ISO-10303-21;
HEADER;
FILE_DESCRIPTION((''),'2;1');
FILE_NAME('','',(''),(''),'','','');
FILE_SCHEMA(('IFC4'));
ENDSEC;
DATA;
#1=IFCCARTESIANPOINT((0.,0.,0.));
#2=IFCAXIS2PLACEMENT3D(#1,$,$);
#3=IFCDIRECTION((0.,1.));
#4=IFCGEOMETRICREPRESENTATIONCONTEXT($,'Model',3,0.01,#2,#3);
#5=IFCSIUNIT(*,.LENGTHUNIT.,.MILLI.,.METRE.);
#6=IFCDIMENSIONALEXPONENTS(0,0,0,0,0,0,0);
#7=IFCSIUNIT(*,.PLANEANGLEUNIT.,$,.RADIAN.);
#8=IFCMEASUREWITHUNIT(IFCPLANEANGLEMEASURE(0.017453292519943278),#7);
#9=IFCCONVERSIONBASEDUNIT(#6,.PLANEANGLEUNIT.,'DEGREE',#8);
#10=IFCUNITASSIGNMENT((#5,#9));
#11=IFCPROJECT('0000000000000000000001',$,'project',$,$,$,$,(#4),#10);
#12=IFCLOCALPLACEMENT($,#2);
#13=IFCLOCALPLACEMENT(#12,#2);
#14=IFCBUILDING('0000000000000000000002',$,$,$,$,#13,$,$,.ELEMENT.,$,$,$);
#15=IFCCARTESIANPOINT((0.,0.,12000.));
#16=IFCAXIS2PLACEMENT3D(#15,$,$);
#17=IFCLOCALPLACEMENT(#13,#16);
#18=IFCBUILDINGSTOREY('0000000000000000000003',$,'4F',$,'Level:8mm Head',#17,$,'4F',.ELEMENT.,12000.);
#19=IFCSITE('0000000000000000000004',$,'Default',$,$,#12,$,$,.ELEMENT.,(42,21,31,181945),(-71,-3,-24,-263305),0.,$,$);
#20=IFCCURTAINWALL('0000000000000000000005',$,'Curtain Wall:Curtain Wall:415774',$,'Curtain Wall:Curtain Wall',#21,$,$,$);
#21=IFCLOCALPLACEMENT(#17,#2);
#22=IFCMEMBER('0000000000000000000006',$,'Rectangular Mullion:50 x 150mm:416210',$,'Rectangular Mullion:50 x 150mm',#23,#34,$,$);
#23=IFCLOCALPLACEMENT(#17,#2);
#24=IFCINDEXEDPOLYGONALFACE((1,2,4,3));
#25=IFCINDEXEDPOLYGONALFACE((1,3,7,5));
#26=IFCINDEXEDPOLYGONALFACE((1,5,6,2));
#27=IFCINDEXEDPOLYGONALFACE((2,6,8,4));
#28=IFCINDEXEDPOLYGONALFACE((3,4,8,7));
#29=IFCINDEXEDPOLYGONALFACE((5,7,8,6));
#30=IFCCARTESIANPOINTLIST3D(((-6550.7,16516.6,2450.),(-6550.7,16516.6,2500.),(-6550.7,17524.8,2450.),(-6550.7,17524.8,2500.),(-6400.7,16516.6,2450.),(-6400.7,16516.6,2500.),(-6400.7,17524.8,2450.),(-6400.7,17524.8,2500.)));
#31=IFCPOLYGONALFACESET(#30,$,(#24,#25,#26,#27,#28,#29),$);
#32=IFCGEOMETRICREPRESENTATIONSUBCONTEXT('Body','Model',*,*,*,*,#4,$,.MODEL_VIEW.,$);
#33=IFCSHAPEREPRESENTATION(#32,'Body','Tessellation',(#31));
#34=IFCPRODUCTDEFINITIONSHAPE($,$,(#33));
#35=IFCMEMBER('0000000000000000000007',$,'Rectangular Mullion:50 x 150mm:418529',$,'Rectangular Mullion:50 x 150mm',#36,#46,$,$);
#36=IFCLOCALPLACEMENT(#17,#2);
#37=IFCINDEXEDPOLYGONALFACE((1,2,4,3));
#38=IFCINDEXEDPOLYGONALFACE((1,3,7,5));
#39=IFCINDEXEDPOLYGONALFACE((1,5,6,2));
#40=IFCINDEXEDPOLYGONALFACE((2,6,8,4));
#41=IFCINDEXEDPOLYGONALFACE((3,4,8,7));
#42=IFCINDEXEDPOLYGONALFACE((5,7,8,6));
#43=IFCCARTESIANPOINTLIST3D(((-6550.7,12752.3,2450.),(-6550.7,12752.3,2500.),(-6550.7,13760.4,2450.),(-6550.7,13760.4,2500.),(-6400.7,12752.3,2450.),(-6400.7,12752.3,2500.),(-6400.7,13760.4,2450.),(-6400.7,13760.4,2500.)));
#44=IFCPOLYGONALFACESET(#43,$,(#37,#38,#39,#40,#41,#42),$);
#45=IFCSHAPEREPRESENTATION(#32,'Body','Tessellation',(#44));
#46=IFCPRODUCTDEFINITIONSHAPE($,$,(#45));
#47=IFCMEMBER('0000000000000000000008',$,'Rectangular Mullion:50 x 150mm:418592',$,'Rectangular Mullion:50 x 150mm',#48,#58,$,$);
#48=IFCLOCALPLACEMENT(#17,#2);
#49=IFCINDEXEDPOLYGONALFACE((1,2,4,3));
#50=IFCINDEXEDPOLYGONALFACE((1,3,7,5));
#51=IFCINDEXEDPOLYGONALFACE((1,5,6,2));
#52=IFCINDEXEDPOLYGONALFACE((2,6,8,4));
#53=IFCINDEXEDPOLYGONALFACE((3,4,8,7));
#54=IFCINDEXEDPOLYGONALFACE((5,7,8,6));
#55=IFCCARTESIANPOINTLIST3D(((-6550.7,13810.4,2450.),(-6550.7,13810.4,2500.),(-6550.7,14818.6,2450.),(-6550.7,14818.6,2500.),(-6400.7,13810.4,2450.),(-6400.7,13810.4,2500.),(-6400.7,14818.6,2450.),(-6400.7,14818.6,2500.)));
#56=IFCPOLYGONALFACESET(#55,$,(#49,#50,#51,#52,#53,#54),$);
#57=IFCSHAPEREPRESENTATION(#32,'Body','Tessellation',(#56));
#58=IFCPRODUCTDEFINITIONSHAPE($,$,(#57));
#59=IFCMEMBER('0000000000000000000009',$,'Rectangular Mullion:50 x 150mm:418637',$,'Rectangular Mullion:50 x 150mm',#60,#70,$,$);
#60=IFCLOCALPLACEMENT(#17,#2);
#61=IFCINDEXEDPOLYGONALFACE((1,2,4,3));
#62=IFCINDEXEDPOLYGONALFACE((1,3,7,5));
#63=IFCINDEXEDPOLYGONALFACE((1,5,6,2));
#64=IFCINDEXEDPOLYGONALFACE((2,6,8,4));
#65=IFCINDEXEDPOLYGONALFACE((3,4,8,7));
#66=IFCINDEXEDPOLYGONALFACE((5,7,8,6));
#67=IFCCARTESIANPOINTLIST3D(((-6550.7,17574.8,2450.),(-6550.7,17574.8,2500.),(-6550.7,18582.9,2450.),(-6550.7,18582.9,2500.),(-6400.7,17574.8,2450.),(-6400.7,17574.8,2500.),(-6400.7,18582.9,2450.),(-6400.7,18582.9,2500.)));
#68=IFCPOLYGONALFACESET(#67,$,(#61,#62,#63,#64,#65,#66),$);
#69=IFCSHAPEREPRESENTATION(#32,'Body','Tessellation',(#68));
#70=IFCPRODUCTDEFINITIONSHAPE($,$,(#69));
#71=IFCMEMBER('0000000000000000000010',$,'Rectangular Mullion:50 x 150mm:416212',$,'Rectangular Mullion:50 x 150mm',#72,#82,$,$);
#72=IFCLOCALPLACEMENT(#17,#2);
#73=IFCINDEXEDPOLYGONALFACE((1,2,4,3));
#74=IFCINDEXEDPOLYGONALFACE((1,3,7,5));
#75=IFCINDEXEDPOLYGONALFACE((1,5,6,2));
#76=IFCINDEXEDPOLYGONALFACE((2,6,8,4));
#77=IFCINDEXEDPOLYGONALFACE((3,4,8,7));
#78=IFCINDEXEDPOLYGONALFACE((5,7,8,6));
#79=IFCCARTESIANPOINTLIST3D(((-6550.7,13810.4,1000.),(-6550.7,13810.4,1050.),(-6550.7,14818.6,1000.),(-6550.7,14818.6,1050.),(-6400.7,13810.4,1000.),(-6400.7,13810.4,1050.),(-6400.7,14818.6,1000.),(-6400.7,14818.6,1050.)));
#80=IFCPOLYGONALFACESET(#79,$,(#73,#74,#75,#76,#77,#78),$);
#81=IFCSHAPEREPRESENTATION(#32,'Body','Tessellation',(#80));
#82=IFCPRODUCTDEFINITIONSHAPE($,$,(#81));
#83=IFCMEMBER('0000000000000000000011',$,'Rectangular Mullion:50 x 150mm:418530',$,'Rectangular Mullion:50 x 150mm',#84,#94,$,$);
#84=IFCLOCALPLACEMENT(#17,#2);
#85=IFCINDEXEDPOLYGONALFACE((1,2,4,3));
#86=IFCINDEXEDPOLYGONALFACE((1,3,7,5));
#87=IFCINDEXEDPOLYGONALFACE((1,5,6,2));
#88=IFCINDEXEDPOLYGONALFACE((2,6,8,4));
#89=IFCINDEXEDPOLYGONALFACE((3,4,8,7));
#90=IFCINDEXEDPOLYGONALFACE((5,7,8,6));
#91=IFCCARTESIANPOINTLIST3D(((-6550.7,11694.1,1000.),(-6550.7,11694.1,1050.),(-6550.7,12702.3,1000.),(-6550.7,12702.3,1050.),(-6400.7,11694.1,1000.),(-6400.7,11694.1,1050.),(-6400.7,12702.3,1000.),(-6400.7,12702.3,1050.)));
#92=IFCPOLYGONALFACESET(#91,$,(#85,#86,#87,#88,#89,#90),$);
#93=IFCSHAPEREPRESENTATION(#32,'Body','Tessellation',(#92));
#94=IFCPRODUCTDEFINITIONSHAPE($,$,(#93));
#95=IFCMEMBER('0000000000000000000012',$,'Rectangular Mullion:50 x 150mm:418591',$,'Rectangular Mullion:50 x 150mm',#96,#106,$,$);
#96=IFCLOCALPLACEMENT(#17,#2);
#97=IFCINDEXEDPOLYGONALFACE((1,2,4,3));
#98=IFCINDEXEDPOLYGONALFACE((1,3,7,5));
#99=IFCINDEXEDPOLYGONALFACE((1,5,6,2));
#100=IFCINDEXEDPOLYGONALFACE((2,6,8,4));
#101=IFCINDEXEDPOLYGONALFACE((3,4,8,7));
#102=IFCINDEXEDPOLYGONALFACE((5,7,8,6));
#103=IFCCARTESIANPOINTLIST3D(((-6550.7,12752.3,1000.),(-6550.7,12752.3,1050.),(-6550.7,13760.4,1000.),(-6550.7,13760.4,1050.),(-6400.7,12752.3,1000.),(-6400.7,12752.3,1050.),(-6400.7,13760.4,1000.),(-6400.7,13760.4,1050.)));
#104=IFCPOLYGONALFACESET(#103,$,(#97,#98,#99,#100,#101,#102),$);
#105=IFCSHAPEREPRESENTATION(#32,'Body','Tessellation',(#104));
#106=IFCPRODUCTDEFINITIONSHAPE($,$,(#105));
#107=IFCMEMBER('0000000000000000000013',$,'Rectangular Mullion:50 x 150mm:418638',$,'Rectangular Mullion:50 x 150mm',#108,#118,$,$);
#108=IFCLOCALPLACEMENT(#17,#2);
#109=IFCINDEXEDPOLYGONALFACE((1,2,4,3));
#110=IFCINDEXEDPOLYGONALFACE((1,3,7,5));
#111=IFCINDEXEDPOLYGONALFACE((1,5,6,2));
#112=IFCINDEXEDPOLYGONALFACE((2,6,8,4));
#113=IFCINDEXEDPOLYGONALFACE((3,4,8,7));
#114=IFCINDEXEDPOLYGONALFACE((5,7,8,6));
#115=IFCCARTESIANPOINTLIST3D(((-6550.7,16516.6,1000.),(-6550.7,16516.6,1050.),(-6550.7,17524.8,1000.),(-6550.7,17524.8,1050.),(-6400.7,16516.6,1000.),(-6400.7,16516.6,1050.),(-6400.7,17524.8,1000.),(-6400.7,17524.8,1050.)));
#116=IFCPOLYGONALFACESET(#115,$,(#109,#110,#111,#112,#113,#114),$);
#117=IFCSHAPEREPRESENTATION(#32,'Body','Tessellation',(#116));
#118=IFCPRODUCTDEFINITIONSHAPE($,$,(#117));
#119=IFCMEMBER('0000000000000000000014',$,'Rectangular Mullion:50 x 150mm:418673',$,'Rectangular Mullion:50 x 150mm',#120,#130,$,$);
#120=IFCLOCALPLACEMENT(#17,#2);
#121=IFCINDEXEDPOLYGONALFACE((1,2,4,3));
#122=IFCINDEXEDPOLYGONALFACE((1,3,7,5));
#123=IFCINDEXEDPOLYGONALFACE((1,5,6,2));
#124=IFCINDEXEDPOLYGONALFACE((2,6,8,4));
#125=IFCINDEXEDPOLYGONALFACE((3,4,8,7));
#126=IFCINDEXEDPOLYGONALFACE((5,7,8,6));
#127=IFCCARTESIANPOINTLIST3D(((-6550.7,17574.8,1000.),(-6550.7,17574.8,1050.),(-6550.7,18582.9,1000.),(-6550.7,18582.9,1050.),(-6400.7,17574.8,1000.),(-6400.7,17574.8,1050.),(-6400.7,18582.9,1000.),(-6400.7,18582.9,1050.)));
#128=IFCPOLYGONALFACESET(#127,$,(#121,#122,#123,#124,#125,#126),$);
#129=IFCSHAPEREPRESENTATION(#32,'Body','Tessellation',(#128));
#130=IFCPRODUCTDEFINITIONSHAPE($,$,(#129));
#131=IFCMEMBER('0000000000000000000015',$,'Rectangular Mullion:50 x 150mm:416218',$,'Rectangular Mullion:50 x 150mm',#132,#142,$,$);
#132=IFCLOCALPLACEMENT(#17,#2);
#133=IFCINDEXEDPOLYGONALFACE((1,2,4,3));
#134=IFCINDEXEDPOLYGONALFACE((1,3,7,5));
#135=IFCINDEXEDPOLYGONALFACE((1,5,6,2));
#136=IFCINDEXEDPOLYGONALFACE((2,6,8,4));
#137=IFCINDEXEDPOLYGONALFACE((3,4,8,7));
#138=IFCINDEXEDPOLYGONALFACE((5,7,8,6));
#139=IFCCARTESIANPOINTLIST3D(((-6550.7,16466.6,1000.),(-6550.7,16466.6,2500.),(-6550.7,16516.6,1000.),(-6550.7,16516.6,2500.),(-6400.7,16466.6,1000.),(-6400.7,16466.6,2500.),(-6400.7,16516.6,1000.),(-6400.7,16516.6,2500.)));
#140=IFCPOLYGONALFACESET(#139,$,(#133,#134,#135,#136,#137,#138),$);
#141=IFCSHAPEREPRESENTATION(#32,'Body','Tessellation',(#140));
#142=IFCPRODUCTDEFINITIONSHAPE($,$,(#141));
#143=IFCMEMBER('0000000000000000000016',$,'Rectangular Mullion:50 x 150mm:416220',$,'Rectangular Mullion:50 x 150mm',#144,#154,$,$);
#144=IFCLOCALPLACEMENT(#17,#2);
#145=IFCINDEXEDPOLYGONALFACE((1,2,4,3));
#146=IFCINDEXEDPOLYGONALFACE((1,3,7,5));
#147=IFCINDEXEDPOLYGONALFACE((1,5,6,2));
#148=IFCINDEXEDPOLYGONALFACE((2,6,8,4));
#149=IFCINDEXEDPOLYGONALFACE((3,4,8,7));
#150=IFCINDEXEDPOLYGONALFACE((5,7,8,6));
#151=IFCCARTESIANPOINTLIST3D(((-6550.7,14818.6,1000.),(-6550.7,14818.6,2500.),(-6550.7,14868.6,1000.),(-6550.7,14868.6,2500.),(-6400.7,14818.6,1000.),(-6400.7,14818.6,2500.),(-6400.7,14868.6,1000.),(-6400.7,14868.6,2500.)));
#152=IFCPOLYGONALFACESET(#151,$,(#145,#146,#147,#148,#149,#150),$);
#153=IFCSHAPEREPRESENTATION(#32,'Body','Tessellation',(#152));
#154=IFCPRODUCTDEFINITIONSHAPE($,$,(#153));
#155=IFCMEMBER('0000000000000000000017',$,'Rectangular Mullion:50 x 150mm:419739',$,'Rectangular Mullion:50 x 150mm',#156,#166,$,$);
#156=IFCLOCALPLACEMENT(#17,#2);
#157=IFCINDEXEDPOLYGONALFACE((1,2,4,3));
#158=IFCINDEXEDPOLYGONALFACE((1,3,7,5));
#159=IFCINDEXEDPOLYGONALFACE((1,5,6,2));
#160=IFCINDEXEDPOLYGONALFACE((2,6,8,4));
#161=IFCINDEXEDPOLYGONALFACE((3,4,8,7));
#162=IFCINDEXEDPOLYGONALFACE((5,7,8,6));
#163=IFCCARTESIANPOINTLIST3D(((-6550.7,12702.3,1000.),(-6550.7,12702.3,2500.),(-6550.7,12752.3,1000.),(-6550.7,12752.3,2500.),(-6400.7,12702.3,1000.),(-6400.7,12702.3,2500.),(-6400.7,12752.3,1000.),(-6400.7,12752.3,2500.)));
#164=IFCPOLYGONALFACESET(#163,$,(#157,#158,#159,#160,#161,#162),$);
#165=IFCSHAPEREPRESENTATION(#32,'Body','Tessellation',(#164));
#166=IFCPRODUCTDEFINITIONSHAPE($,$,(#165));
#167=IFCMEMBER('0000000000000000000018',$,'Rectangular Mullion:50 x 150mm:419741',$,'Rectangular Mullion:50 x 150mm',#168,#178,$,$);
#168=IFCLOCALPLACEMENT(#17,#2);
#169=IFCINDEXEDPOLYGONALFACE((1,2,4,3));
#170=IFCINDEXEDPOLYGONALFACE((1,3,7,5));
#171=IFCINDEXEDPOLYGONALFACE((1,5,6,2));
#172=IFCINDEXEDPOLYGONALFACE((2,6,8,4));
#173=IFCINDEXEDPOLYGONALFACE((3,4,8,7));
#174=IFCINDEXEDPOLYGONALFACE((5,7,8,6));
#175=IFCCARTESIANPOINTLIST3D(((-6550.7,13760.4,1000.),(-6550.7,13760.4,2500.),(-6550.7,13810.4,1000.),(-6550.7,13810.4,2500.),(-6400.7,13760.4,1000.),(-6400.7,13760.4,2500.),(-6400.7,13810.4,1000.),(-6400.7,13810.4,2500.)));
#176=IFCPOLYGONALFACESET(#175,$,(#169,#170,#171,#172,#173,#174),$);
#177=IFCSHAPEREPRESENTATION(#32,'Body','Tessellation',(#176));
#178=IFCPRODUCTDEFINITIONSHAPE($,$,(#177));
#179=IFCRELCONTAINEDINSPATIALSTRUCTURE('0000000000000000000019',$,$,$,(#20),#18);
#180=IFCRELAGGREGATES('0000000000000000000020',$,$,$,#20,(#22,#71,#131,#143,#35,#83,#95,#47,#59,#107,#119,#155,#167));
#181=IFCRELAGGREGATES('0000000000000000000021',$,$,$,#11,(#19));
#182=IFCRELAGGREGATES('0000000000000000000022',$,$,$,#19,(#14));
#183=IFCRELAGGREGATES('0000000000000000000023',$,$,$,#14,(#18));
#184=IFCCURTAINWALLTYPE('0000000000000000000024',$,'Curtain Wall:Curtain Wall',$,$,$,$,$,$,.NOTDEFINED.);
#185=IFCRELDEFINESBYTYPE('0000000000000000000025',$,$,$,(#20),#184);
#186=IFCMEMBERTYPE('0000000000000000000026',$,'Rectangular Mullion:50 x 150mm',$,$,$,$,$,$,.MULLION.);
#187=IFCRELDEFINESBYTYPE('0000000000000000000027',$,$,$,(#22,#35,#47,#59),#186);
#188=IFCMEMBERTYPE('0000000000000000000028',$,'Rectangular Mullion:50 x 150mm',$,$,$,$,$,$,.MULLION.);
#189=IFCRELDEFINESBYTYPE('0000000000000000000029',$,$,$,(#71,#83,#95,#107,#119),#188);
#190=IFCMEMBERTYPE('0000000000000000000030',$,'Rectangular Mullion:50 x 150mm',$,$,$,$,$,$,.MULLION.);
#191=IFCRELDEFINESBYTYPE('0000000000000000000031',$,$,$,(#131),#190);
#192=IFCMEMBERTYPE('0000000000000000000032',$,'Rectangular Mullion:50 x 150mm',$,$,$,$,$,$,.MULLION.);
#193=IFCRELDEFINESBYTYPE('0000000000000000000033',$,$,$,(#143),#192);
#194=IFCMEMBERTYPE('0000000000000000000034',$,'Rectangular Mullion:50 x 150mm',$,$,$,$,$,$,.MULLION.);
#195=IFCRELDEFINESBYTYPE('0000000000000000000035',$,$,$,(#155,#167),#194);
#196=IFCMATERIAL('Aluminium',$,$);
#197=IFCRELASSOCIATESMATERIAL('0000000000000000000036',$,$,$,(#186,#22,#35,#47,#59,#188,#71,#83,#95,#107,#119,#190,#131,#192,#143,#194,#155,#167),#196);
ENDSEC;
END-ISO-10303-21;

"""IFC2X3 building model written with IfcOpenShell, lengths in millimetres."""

from ifc_helpers import new_model, entity, si_unit, converted_unit, direction, frame, origin, origin_2d_with_axis, place, context, subcontext, project, spatial, rectangle, extrude, source, transform, mapped, material, type_object, type_shapes, element, aggregate, save


model = new_model("IFC2X3")

# Units and contexts
model_context = context("Model", 3, precision=0.01, world=origin(), true_north=direction((0.0, 1.0)))
body_context = subcontext(model_context, "Body", "Model", "MODEL_VIEW")
ifc_project = project(units=[si_unit("LENGTHUNIT", "METRE", prefix="MILLI"), converted_unit("PLANEANGLEUNIT", "DEGREE", entity("IfcPlaneAngleMeasure", 0.017453292519943278), si_unit("PLANEANGLEUNIT", "RADIAN"), dimensions=[0, 0, 0, 0, 0, 0, 0])], contexts=[model_context])

# Site, building, storey
site_placement = place(None, origin())
site = spatial("IfcSite", under=ifc_project, at=site_placement, Name="Default", CompositionType="ELEMENT", RefLatitude=(42, 21, 31, 181945), RefLongitude=(-71, -3, -24, -263305), RefElevation=0.0)
building_placement = place(site_placement, origin())
building = spatial("IfcBuilding", under=site, at=building_placement, CompositionType="ELEMENT")
storey_placement = place(building_placement, frame((0.0, 0.0, 12000.0)))
storey = spatial("IfcBuildingStorey", under=building, at=storey_placement, Name="4F", ObjectType="Level:8mm Head", LongName="4F", CompositionType="ELEMENT", Elevation=12000.0)

# Curtain wall, members
curtain_wall_type = type_object("IfcCurtainWallType", Name="Curtain Wall:Curtain Wall", PredefinedType="NOTDEFINED")
curtain_wall_placement = place(storey_placement, frame((0.0, 0.0, -12000.0)))
curtain_wall = element("IfcCurtainWall", 1, at=curtain_wall_placement, inside=storey, type_object=curtain_wall_type, Name="Curtain Wall:Curtain Wall:415774", ObjectType="Curtain Wall:Curtain Wall")
ifc_material_1 = material(Name="Aluminium")
member_type_1 = type_object("IfcMemberType", Name="Rectangular Mullion:50 x 150mm", PredefinedType="MULLION", material=ifc_material_1)
shared_shape_1 = source(origin(), body_context, "Body", "SweptSolid", [
    extrude(rectangle(XDim=50.0, YDim=150.0, at=origin_2d_with_axis()), frame((-25.0, 0.0, -1008.2), z_axis=(0.0, 0.0, 1.0), x_axis=(-1.0, 0.0, 0.0)), (0.0, 0.0, 1.0), 1008.2),
])
type_shapes(member_type_1, [shared_shape_1])
member_1_placement = place(curtain_wall_placement, frame((-6475.7, 16516.6, 14500.0), z_axis=(0.0, -1.0, 0.0), x_axis=(0.0, 0.0, 1.0)))
member_1 = element("IfcMember", 2, at=member_1_placement, type_object=member_type_1, material=ifc_material_1, Name="Rectangular Mullion:50 x 150mm:416210", ObjectType="Rectangular Mullion:50 x 150mm", context=body_context, shape_type="MappedRepresentation", body=[
    mapped(shared_shape_1, transform((0.0, 0.0, 0.0), scale=1.0)),
])
member_2_placement = place(curtain_wall_placement, frame((-6475.7, 12752.3, 14500.0), z_axis=(0.0, -1.0, 0.0), x_axis=(0.0, 0.0, 1.0)))
member_2 = element("IfcMember", 3, at=member_2_placement, type_object=member_type_1, material=ifc_material_1, Name="Rectangular Mullion:50 x 150mm:418529", ObjectType="Rectangular Mullion:50 x 150mm", context=body_context, shape_type="MappedRepresentation", body=[
    mapped(shared_shape_1, transform((0.0, 0.0, 0.0), scale=1.0)),
])
member_3_placement = place(curtain_wall_placement, frame((-6475.7, 13810.4, 14500.0), z_axis=(0.0, -1.0, 0.0), x_axis=(0.0, 0.0, 1.0)))
member_3 = element("IfcMember", 4, at=member_3_placement, type_object=member_type_1, material=ifc_material_1, Name="Rectangular Mullion:50 x 150mm:418592", ObjectType="Rectangular Mullion:50 x 150mm", context=body_context, shape_type="MappedRepresentation", body=[
    mapped(shared_shape_1, transform((0.0, 0.0, 0.0), scale=1.0)),
])
member_4_placement = place(curtain_wall_placement, frame((-6475.7, 17574.8, 14500.0), z_axis=(0.0, -1.0, 0.0), x_axis=(0.0, 0.0, 1.0)))
member_4 = element("IfcMember", 5, at=member_4_placement, type_object=member_type_1, material=ifc_material_1, Name="Rectangular Mullion:50 x 150mm:418637", ObjectType="Rectangular Mullion:50 x 150mm", context=body_context, shape_type="MappedRepresentation", body=[
    mapped(shared_shape_1, transform((0.0, 0.0, 0.0), scale=1.0)),
])
member_type_2 = type_object("IfcMemberType", Name="Rectangular Mullion:50 x 150mm", PredefinedType="MULLION", material=ifc_material_1)
shared_shape_2 = source(origin(), body_context, "Body", "SweptSolid", [
    extrude(rectangle(XDim=50.0, YDim=150.0, at=origin_2d_with_axis()), frame((-25.0, 0.0, -1008.2), z_axis=(0.0, 0.0, 1.0), x_axis=(-1.0, 0.0, 0.0)), (0.0, 0.0, 1.0), 1008.2),
])
type_shapes(member_type_2, [shared_shape_2])
member_5_placement = place(curtain_wall_placement, frame((-6475.7, 14818.6, 13000.0), z_axis=(0.0, 1.0, 0.0), x_axis=(0.0, 0.0, -1.0)))
member_5 = element("IfcMember", 6, at=member_5_placement, type_object=member_type_2, material=ifc_material_1, Name="Rectangular Mullion:50 x 150mm:416212", ObjectType="Rectangular Mullion:50 x 150mm", context=body_context, shape_type="MappedRepresentation", body=[
    mapped(shared_shape_2, transform((0.0, 0.0, 0.0), scale=1.0)),
])
member_6_placement = place(curtain_wall_placement, frame((-6475.7, 12702.3, 13000.0), z_axis=(0.0, 1.0, 0.0), x_axis=(0.0, 0.0, -1.0)))
member_6 = element("IfcMember", 7, at=member_6_placement, type_object=member_type_2, material=ifc_material_1, Name="Rectangular Mullion:50 x 150mm:418530", ObjectType="Rectangular Mullion:50 x 150mm", context=body_context, shape_type="MappedRepresentation", body=[
    mapped(shared_shape_2, transform((0.0, 0.0, 0.0), scale=1.0)),
])
member_7_placement = place(curtain_wall_placement, frame((-6475.7, 13760.4, 13000.0), z_axis=(0.0, 1.0, 0.0), x_axis=(0.0, 0.0, -1.0)))
member_7 = element("IfcMember", 8, at=member_7_placement, type_object=member_type_2, material=ifc_material_1, Name="Rectangular Mullion:50 x 150mm:418591", ObjectType="Rectangular Mullion:50 x 150mm", context=body_context, shape_type="MappedRepresentation", body=[
    mapped(shared_shape_2, transform((0.0, 0.0, 0.0), scale=1.0)),
])
member_8_placement = place(curtain_wall_placement, frame((-6475.7, 17524.8, 13000.0), z_axis=(0.0, 1.0, 0.0), x_axis=(0.0, 0.0, -1.0)))
member_8 = element("IfcMember", 9, at=member_8_placement, type_object=member_type_2, material=ifc_material_1, Name="Rectangular Mullion:50 x 150mm:418638", ObjectType="Rectangular Mullion:50 x 150mm", context=body_context, shape_type="MappedRepresentation", body=[
    mapped(shared_shape_2, transform((0.0, 0.0, 0.0), scale=1.0)),
])
member_9_placement = place(curtain_wall_placement, frame((-6475.7, 18582.9, 13000.0), z_axis=(0.0, 1.0, 0.0), x_axis=(0.0, 0.0, -1.0)))
member_9 = element("IfcMember", 10, at=member_9_placement, type_object=member_type_2, material=ifc_material_1, Name="Rectangular Mullion:50 x 150mm:418673", ObjectType="Rectangular Mullion:50 x 150mm", context=body_context, shape_type="MappedRepresentation", body=[
    mapped(shared_shape_2, transform((0.0, 0.0, 0.0), scale=1.0)),
])
member_type_3 = type_object("IfcMemberType", Name="Rectangular Mullion:50 x 150mm", PredefinedType="MULLION", material=ifc_material_1)
shared_shape_3 = source(origin(), body_context, "Body", "SweptSolid", [
    extrude(rectangle(XDim=50.0, YDim=150.0, at=origin_2d_with_axis()), frame((-25.0, 0.0, -1500.0), z_axis=(0.0, 0.0, 1.0), x_axis=(-1.0, 0.0, 0.0)), (0.0, 0.0, 1.0), 1500.0),
])
type_shapes(member_type_3, [shared_shape_3])
member_10_placement = place(curtain_wall_placement, frame((-6475.7, 16466.6, 13000.0), z_axis=(0.0, 0.0, -1.0), x_axis=(0.0, -1.0, 0.0)))
member_10 = element("IfcMember", 11, at=member_10_placement, type_object=member_type_3, material=ifc_material_1, Name="Rectangular Mullion:50 x 150mm:416218", ObjectType="Rectangular Mullion:50 x 150mm", context=body_context, shape_type="MappedRepresentation", body=[
    mapped(shared_shape_3, transform((0.0, 0.0, 0.0), scale=1.0)),
])
member_type_4 = type_object("IfcMemberType", Name="Rectangular Mullion:50 x 150mm", PredefinedType="MULLION", material=ifc_material_1)
shared_shape_4 = source(origin(), body_context, "Body", "SweptSolid", [
    extrude(rectangle(XDim=50.0, YDim=150.0, at=origin_2d_with_axis()), frame((-25.0, 0.0, -1500.0), z_axis=(0.0, 0.0, 1.0), x_axis=(-1.0, 0.0, 0.0)), (0.0, 0.0, 1.0), 1500.0),
])
type_shapes(member_type_4, [shared_shape_4])
member_11_placement = place(curtain_wall_placement, frame((-6475.7, 14868.6, 14500.0), z_axis=(0.0, 0.0, 1.0), x_axis=(0.0, 1.0, 0.0)))
member_11 = element("IfcMember", 12, at=member_11_placement, type_object=member_type_4, material=ifc_material_1, Name="Rectangular Mullion:50 x 150mm:416220", ObjectType="Rectangular Mullion:50 x 150mm", context=body_context, shape_type="MappedRepresentation", body=[
    mapped(shared_shape_4, transform((0.0, 0.0, 0.0), scale=1.0)),
])
member_type_5 = type_object("IfcMemberType", Name="Rectangular Mullion:50 x 150mm", PredefinedType="MULLION", material=ifc_material_1)
shared_shape_5 = source(origin(), body_context, "Body", "SweptSolid", [
    extrude(rectangle(XDim=50.0, YDim=150.0, at=origin_2d_with_axis()), frame((0.0, 0.0, -1500.0), z_axis=(0.0, 0.0, 1.0), x_axis=(-1.0, 0.0, 0.0)), (0.0, 0.0, 1.0), 1500.0),
])
type_shapes(member_type_5, [shared_shape_5])
member_12_placement = place(curtain_wall_placement, frame((-6475.7, 12727.3, 13000.0), z_axis=(0.0, 0.0, -1.0), x_axis=(0.0, -1.0, 0.0)))
member_12 = element("IfcMember", 13, at=member_12_placement, type_object=member_type_5, material=ifc_material_1, Name="Rectangular Mullion:50 x 150mm:419739", ObjectType="Rectangular Mullion:50 x 150mm", context=body_context, shape_type="MappedRepresentation", body=[
    mapped(shared_shape_5, transform((0.0, 0.0, 0.0), scale=1.0)),
])
member_13_placement = place(curtain_wall_placement, frame((-6475.7, 13785.4, 13000.0), z_axis=(0.0, 0.0, -1.0), x_axis=(0.0, -1.0, 0.0)))
member_13 = element("IfcMember", 14, at=member_13_placement, type_object=member_type_5, material=ifc_material_1, Name="Rectangular Mullion:50 x 150mm:419741", ObjectType="Rectangular Mullion:50 x 150mm", context=body_context, shape_type="MappedRepresentation", body=[
    mapped(shared_shape_5, transform((0.0, 0.0, 0.0), scale=1.0)),
])
aggregate(curtain_wall, [member_1, member_5, member_10, member_11, member_2, member_6, member_7, member_3, member_4, member_8, member_9, member_12, member_13])

save(model, "model.ifc")
